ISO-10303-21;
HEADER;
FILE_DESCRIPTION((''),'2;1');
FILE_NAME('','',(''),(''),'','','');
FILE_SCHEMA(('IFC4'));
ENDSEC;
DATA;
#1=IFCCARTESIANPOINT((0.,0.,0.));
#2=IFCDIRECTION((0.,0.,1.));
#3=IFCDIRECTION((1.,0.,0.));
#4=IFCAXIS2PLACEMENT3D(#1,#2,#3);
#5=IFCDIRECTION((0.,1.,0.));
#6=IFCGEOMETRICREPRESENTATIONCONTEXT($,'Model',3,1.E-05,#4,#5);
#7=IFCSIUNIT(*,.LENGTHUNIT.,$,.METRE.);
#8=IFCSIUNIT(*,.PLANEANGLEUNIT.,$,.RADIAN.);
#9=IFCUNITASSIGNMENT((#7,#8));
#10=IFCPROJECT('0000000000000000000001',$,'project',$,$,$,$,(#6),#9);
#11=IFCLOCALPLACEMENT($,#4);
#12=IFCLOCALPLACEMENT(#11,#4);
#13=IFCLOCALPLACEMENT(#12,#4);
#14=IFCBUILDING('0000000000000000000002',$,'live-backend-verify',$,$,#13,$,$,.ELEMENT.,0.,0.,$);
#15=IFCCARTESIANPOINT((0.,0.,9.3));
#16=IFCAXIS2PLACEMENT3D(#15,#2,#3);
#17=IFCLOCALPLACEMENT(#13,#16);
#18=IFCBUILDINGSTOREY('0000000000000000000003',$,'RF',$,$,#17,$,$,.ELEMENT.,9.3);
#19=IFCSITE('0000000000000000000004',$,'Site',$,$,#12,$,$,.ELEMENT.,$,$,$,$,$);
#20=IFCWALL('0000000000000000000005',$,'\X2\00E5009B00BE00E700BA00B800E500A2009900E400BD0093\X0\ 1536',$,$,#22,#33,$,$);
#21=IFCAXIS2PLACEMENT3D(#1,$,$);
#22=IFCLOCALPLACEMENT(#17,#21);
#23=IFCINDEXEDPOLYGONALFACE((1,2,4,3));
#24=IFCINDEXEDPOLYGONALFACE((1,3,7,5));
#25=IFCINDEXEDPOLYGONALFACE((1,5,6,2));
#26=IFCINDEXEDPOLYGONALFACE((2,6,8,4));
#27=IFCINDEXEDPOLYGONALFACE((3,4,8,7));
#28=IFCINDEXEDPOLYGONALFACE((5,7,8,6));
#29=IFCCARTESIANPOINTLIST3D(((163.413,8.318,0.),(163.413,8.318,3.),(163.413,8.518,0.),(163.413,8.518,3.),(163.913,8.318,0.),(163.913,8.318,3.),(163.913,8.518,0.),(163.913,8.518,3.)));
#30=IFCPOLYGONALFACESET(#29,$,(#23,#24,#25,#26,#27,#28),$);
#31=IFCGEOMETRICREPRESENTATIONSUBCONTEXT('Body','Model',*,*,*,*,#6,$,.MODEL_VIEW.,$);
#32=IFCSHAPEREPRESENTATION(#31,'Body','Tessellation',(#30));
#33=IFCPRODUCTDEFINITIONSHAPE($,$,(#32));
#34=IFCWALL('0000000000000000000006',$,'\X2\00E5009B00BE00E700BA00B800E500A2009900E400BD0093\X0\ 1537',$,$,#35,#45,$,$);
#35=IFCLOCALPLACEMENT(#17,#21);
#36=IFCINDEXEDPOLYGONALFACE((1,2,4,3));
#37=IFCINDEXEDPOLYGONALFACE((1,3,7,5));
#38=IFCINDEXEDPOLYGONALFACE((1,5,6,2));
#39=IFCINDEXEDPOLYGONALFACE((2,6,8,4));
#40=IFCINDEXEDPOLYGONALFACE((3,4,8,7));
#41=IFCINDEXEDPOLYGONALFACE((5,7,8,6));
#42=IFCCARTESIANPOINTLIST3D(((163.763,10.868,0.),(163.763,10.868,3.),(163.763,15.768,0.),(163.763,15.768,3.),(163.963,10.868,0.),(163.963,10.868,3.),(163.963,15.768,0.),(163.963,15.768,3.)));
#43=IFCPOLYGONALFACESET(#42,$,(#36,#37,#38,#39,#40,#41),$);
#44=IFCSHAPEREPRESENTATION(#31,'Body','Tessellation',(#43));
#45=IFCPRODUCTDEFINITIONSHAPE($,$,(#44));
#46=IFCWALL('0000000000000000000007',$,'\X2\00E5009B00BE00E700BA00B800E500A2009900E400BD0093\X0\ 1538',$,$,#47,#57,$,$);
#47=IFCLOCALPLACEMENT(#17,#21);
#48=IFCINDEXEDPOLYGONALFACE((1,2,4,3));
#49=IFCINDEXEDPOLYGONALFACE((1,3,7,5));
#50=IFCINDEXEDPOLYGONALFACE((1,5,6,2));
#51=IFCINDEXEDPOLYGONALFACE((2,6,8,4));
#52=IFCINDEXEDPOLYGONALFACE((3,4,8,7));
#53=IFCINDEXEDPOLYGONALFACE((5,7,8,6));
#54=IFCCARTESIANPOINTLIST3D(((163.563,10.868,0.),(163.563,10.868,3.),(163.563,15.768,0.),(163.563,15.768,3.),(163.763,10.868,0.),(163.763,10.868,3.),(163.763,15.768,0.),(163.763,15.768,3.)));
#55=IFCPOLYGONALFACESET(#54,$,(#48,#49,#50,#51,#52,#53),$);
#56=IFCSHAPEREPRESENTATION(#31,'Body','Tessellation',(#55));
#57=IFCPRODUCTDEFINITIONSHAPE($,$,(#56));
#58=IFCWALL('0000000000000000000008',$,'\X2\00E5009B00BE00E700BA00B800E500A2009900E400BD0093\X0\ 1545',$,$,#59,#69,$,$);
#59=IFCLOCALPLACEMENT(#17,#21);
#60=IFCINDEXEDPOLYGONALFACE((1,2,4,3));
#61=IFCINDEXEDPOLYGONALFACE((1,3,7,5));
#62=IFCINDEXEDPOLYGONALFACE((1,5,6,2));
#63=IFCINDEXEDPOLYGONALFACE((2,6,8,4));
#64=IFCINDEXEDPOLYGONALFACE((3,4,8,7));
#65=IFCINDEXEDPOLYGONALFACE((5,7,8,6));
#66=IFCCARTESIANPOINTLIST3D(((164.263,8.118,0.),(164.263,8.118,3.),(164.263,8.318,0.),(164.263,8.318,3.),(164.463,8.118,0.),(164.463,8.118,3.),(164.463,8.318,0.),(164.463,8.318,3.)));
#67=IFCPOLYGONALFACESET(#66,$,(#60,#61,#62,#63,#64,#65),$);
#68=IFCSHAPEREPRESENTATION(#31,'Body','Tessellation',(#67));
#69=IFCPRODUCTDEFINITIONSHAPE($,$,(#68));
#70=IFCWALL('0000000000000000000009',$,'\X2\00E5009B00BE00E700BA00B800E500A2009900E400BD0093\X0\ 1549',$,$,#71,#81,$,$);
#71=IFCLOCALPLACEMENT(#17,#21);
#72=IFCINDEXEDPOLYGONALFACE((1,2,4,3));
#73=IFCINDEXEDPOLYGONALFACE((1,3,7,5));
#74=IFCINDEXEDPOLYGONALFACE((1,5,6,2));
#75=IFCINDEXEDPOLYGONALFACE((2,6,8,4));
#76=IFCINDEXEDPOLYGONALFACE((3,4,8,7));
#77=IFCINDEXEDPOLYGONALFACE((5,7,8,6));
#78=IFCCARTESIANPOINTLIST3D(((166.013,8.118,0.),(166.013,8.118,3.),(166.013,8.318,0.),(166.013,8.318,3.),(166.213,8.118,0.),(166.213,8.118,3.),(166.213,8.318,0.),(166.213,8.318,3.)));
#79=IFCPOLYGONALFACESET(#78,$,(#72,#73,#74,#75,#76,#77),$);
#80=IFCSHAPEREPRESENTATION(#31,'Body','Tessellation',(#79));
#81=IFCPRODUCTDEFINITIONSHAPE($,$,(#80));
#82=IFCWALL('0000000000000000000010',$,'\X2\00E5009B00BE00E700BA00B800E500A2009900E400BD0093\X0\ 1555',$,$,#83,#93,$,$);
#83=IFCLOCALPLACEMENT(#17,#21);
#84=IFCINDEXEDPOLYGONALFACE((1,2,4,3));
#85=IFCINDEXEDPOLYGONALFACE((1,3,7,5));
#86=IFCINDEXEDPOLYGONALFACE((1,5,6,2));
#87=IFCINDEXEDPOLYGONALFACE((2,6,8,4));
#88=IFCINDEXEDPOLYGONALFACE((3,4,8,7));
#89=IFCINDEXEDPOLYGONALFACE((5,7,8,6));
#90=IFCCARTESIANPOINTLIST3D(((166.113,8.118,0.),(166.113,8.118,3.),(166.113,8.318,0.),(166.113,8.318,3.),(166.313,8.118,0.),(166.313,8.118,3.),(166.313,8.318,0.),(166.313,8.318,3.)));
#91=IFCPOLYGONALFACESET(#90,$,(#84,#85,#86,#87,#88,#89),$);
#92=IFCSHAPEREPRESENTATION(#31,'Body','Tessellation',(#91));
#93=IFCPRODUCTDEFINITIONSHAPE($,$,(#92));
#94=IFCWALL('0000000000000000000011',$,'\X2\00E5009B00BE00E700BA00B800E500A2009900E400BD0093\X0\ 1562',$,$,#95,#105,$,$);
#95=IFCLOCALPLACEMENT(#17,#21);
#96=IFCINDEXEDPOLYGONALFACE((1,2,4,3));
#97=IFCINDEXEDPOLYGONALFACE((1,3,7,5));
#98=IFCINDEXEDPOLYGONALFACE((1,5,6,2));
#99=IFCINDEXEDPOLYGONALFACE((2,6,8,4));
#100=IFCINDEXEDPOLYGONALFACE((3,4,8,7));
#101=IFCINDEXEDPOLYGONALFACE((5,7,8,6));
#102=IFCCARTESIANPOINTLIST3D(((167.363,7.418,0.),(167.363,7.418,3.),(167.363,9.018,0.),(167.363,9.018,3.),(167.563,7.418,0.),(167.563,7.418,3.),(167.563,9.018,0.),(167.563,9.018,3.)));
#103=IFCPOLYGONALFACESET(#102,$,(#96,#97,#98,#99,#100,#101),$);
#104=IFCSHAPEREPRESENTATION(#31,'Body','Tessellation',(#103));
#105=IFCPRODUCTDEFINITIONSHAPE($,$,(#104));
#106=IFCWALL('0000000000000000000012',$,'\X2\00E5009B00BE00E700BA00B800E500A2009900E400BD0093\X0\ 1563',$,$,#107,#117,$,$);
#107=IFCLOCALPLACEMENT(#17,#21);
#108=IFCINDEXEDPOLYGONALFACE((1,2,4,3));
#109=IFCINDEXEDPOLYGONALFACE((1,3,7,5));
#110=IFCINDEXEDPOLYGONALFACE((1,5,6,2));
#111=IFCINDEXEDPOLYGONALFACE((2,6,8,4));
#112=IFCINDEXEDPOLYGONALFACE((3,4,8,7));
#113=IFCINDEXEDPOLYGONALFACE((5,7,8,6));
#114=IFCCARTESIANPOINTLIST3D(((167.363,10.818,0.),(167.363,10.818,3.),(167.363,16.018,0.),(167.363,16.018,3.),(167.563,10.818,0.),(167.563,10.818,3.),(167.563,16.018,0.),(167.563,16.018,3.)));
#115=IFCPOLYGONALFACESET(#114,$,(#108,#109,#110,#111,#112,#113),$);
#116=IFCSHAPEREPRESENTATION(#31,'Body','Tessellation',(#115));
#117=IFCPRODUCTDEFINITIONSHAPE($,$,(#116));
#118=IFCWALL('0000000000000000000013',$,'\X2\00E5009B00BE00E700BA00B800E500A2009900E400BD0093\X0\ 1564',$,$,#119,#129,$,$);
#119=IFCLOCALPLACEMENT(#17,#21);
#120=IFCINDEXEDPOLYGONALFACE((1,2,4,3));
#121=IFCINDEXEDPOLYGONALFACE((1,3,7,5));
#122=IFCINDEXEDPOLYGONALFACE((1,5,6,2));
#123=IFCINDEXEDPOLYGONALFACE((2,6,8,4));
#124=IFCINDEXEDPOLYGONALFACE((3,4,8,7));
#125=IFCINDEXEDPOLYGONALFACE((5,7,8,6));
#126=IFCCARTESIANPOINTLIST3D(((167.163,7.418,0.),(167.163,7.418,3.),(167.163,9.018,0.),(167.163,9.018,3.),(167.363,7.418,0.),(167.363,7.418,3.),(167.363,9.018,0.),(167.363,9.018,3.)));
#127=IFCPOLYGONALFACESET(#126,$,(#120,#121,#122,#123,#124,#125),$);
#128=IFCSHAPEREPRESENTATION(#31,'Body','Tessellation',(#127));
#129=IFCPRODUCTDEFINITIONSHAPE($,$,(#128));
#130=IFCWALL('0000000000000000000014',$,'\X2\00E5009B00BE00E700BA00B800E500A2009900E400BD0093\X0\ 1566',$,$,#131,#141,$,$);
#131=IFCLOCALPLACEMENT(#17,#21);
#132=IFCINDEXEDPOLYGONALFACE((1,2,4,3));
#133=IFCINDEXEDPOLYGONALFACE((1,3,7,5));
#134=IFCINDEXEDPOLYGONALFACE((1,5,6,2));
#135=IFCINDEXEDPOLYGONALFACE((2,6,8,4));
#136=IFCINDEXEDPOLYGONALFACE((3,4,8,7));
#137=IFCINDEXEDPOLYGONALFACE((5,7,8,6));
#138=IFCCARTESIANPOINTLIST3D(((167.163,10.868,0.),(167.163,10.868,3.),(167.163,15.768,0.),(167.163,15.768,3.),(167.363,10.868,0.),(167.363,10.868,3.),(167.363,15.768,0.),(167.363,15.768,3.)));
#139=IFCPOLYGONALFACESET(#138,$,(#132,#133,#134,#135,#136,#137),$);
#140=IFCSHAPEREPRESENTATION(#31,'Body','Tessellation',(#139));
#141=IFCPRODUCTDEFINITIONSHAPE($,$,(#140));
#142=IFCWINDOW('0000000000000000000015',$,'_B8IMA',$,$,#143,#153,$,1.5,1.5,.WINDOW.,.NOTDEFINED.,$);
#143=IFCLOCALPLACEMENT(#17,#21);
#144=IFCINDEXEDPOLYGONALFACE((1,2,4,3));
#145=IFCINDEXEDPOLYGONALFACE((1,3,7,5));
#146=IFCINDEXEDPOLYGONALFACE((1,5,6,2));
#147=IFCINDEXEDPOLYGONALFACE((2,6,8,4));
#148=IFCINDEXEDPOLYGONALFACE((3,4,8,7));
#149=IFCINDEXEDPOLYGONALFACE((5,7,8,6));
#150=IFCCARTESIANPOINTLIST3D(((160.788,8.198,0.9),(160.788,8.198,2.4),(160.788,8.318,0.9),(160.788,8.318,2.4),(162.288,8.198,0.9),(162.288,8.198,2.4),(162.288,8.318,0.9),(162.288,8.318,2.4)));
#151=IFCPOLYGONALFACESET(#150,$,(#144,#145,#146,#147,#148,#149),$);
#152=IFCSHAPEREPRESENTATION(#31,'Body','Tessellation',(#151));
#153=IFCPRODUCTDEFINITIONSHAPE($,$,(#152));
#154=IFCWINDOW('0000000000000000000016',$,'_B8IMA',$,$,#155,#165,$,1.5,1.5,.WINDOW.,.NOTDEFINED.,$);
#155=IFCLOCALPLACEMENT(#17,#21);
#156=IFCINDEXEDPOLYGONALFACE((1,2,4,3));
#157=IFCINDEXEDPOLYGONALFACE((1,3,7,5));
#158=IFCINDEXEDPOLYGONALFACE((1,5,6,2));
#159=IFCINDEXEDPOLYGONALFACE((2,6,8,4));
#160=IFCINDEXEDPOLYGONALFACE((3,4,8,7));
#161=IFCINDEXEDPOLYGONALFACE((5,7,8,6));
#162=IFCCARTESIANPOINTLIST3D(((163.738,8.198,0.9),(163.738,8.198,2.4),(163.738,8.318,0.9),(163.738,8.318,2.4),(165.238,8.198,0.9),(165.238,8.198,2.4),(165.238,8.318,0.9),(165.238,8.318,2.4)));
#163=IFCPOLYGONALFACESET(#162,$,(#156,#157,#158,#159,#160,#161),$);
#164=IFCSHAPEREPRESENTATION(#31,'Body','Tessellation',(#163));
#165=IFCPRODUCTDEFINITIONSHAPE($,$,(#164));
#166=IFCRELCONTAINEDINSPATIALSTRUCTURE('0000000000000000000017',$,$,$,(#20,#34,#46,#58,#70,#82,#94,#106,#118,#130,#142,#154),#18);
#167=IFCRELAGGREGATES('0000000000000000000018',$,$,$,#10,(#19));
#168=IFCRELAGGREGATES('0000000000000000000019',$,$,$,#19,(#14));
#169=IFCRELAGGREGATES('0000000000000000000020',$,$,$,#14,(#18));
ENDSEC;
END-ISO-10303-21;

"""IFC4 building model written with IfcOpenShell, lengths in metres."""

from ifc_helpers import new_model, si_unit, direction, frame, frame_2d, origin_with_axes, place, context, subcontext, project, spatial, rectangle, extrude, element, save


model = new_model("IFC4")

# Units and contexts
model_context = context("Model", 3, precision=1e-05, world=origin_with_axes(), true_north=direction((0.0, 1.0, 0.0)))
body_context = subcontext(model_context, "Body", "Model", "MODEL_VIEW")
ifc_project = project(units=[si_unit("LENGTHUNIT", "METRE"), si_unit("PLANEANGLEUNIT", "RADIAN")], contexts=[model_context])

# Site, building, storey
placement = place(None, origin_with_axes())
site_placement = place(placement, origin_with_axes())
site = spatial("IfcSite", under=ifc_project, at=site_placement, Name="Site", CompositionType="ELEMENT")
building_placement = place(site_placement, origin_with_axes())
building = spatial("IfcBuilding", under=site, at=building_placement, Name="live-backend-verify", CompositionType="ELEMENT", ElevationOfRefHeight=0.0, ElevationOfTerrain=0.0)
storey_placement = place(building_placement, frame((0.0, 0.0, 9.3), z_axis=(0.0, 0.0, 1.0), x_axis=(1.0, 0.0, 0.0)))
storey = spatial("IfcBuildingStorey", under=building, at=storey_placement, Name="RF", CompositionType="ELEMENT", Elevation=9.3)

# Walls
for number, where, z_axis, x_axis, name in (
    (1, (163.663, 8.418, 0.0), (0.0, 0.0, 1.0), (-1.0, 0.0, 0.0), "å\u009b¾çº¸å¢\u0099ä½\u0093 1536"),
):
    element("IfcWall", number, at=place(storey_placement, frame(where, z_axis=z_axis, x_axis=x_axis)), inside=storey, Name=name, context=body_context, shape_type="SweptSolid", body=[
        extrude(rectangle(XDim=0.5, YDim=0.2, at=frame_2d((0.0, 0.0), x_axis=(1.0, 0.0, 0.0))), frame((0.0, 0.0, 0.0), z_axis=(0.0, 0.0, 1.0)), (0.0, 0.0, 1.0), 3.0),
    ])
for number, where, z_axis, x_axis, name in (
    (2, (163.863, 13.318, 0.0), (0.0, 0.0, 1.0), (0.0, -1.0, 0.0), "å\u009b¾çº¸å¢\u0099ä½\u0093 1537"),
    (3, (163.663, 13.318, 0.0), (0.0, 0.0, 1.0), (0.0, -1.0, 0.0), "å\u009b¾çº¸å¢\u0099ä½\u0093 1538"),
):
    element("IfcWall", number, at=place(storey_placement, frame(where, z_axis=z_axis, x_axis=x_axis)), inside=storey, Name=name, context=body_context, shape_type="SweptSolid", body=[
        extrude(rectangle(XDim=4.9, YDim=0.2, at=frame_2d((0.0, 0.0), x_axis=(1.0, 0.0, 0.0))), frame((0.0, 0.0, 0.0), z_axis=(0.0, 0.0, 1.0)), (0.0, 0.0, 1.0), 3.0),
    ])
for number, where, z_axis, x_axis, name in (
    (4, (164.363, 8.218, 0.0), (0.0, 0.0, 1.0), (0.0, 1.0, 0.0), "å\u009b¾çº¸å¢\u0099ä½\u0093 1545"),
    (5, (166.113, 8.218, 0.0), (0.0, 0.0, 1.0), (0.0, 1.0, 0.0), "å\u009b¾çº¸å¢\u0099ä½\u0093 1549"),
    (6, (166.213, 8.218, 0.0), (0.0, 0.0, 1.0), (0.0, -1.0, 0.0), "å\u009b¾çº¸å¢\u0099ä½\u0093 1555"),
):
    element("IfcWall", number, at=place(storey_placement, frame(where, z_axis=z_axis, x_axis=x_axis)), inside=storey, Name=name, context=body_context, shape_type="SweptSolid", body=[
        extrude(rectangle(XDim=0.2, YDim=0.2, at=frame_2d((0.0, 0.0), x_axis=(1.0, 0.0, 0.0))), frame((0.0, 0.0, 0.0), z_axis=(0.0, 0.0, 1.0)), (0.0, 0.0, 1.0), 3.0),
    ])
wall_1_placement = place(storey_placement, frame((167.463, 8.218, 0.0), z_axis=(0.0, 0.0, 1.0), x_axis=(0.0, -1.0, 0.0)))
element("IfcWall", 7, at=wall_1_placement, inside=storey, Name="å\u009b¾çº¸å¢\u0099ä½\u0093 1562", context=body_context, shape_type="SweptSolid", body=[
    extrude(rectangle(XDim=1.6, YDim=0.2, at=frame_2d((0.0, 0.0), x_axis=(1.0, 0.0, 0.0))), frame((0.0, 0.0, 0.0), z_axis=(0.0, 0.0, 1.0)), (0.0, 0.0, 1.0), 3.0),
])
wall_2_placement = place(storey_placement, frame((167.463, 13.418, 0.0), z_axis=(0.0, 0.0, 1.0), x_axis=(0.0, -1.0, 0.0)))
element("IfcWall", 8, at=wall_2_placement, inside=storey, Name="å\u009b¾çº¸å¢\u0099ä½\u0093 1563", context=body_context, shape_type="SweptSolid", body=[
    extrude(rectangle(XDim=5.2, YDim=0.2, at=frame_2d((0.0, 0.0), x_axis=(1.0, 0.0, 0.0))), frame((0.0, 0.0, 0.0), z_axis=(0.0, 0.0, 1.0)), (0.0, 0.0, 1.0), 3.0),
])
wall_3_placement = place(storey_placement, frame((167.263, 8.218, 0.0), z_axis=(0.0, 0.0, 1.0), x_axis=(0.0, -1.0, 0.0)))
element("IfcWall", 9, at=wall_3_placement, inside=storey, Name="å\u009b¾çº¸å¢\u0099ä½\u0093 1564", context=body_context, shape_type="SweptSolid", body=[
    extrude(rectangle(XDim=1.6, YDim=0.2, at=frame_2d((0.0, 0.0), x_axis=(1.0, 0.0, 0.0))), frame((0.0, 0.0, 0.0), z_axis=(0.0, 0.0, 1.0)), (0.0, 0.0, 1.0), 3.0),
])
wall_4_placement = place(storey_placement, frame((167.263, 13.318, 0.0), z_axis=(0.0, 0.0, 1.0), x_axis=(0.0, -1.0, 0.0)))
element("IfcWall", 10, at=wall_4_placement, inside=storey, Name="å\u009b¾çº¸å¢\u0099ä½\u0093 1566", context=body_context, shape_type="SweptSolid", body=[
    extrude(rectangle(XDim=4.9, YDim=0.2, at=frame_2d((0.0, 0.0), x_axis=(1.0, 0.0, 0.0))), frame((0.0, 0.0, 0.0), z_axis=(0.0, 0.0, 1.0)), (0.0, 0.0, 1.0), 3.0),
])

# Windows
for number, where, z_axis, x_axis, name in (
    (11, (161.538, 8.258, 0.9), (0.0, 0.0, 1.0), (1.0, 0.0, 0.0), "_B8IMA"),
    (12, (164.488, 8.258, 0.9), (0.0, 0.0, 1.0), (1.0, 0.0, 0.0), "_B8IMA"),
):
    element("IfcWindow", number, at=place(storey_placement, frame(where, z_axis=z_axis, x_axis=x_axis)), inside=storey, Name=name, OverallHeight=1.5, OverallWidth=1.5, PartitioningType="NOTDEFINED", PredefinedType="WINDOW", context=body_context, shape_type="SweptSolid", body=[
        extrude(rectangle(XDim=1.5, YDim=0.12, at=frame_2d((0.0, 0.0), x_axis=(1.0, 0.0, 0.0))), frame((0.0, 0.0, 0.0), z_axis=(0.0, 0.0, 1.0)), (0.0, 0.0, 1.0), 1.5),
    ])

save(model, "model.ifc")
